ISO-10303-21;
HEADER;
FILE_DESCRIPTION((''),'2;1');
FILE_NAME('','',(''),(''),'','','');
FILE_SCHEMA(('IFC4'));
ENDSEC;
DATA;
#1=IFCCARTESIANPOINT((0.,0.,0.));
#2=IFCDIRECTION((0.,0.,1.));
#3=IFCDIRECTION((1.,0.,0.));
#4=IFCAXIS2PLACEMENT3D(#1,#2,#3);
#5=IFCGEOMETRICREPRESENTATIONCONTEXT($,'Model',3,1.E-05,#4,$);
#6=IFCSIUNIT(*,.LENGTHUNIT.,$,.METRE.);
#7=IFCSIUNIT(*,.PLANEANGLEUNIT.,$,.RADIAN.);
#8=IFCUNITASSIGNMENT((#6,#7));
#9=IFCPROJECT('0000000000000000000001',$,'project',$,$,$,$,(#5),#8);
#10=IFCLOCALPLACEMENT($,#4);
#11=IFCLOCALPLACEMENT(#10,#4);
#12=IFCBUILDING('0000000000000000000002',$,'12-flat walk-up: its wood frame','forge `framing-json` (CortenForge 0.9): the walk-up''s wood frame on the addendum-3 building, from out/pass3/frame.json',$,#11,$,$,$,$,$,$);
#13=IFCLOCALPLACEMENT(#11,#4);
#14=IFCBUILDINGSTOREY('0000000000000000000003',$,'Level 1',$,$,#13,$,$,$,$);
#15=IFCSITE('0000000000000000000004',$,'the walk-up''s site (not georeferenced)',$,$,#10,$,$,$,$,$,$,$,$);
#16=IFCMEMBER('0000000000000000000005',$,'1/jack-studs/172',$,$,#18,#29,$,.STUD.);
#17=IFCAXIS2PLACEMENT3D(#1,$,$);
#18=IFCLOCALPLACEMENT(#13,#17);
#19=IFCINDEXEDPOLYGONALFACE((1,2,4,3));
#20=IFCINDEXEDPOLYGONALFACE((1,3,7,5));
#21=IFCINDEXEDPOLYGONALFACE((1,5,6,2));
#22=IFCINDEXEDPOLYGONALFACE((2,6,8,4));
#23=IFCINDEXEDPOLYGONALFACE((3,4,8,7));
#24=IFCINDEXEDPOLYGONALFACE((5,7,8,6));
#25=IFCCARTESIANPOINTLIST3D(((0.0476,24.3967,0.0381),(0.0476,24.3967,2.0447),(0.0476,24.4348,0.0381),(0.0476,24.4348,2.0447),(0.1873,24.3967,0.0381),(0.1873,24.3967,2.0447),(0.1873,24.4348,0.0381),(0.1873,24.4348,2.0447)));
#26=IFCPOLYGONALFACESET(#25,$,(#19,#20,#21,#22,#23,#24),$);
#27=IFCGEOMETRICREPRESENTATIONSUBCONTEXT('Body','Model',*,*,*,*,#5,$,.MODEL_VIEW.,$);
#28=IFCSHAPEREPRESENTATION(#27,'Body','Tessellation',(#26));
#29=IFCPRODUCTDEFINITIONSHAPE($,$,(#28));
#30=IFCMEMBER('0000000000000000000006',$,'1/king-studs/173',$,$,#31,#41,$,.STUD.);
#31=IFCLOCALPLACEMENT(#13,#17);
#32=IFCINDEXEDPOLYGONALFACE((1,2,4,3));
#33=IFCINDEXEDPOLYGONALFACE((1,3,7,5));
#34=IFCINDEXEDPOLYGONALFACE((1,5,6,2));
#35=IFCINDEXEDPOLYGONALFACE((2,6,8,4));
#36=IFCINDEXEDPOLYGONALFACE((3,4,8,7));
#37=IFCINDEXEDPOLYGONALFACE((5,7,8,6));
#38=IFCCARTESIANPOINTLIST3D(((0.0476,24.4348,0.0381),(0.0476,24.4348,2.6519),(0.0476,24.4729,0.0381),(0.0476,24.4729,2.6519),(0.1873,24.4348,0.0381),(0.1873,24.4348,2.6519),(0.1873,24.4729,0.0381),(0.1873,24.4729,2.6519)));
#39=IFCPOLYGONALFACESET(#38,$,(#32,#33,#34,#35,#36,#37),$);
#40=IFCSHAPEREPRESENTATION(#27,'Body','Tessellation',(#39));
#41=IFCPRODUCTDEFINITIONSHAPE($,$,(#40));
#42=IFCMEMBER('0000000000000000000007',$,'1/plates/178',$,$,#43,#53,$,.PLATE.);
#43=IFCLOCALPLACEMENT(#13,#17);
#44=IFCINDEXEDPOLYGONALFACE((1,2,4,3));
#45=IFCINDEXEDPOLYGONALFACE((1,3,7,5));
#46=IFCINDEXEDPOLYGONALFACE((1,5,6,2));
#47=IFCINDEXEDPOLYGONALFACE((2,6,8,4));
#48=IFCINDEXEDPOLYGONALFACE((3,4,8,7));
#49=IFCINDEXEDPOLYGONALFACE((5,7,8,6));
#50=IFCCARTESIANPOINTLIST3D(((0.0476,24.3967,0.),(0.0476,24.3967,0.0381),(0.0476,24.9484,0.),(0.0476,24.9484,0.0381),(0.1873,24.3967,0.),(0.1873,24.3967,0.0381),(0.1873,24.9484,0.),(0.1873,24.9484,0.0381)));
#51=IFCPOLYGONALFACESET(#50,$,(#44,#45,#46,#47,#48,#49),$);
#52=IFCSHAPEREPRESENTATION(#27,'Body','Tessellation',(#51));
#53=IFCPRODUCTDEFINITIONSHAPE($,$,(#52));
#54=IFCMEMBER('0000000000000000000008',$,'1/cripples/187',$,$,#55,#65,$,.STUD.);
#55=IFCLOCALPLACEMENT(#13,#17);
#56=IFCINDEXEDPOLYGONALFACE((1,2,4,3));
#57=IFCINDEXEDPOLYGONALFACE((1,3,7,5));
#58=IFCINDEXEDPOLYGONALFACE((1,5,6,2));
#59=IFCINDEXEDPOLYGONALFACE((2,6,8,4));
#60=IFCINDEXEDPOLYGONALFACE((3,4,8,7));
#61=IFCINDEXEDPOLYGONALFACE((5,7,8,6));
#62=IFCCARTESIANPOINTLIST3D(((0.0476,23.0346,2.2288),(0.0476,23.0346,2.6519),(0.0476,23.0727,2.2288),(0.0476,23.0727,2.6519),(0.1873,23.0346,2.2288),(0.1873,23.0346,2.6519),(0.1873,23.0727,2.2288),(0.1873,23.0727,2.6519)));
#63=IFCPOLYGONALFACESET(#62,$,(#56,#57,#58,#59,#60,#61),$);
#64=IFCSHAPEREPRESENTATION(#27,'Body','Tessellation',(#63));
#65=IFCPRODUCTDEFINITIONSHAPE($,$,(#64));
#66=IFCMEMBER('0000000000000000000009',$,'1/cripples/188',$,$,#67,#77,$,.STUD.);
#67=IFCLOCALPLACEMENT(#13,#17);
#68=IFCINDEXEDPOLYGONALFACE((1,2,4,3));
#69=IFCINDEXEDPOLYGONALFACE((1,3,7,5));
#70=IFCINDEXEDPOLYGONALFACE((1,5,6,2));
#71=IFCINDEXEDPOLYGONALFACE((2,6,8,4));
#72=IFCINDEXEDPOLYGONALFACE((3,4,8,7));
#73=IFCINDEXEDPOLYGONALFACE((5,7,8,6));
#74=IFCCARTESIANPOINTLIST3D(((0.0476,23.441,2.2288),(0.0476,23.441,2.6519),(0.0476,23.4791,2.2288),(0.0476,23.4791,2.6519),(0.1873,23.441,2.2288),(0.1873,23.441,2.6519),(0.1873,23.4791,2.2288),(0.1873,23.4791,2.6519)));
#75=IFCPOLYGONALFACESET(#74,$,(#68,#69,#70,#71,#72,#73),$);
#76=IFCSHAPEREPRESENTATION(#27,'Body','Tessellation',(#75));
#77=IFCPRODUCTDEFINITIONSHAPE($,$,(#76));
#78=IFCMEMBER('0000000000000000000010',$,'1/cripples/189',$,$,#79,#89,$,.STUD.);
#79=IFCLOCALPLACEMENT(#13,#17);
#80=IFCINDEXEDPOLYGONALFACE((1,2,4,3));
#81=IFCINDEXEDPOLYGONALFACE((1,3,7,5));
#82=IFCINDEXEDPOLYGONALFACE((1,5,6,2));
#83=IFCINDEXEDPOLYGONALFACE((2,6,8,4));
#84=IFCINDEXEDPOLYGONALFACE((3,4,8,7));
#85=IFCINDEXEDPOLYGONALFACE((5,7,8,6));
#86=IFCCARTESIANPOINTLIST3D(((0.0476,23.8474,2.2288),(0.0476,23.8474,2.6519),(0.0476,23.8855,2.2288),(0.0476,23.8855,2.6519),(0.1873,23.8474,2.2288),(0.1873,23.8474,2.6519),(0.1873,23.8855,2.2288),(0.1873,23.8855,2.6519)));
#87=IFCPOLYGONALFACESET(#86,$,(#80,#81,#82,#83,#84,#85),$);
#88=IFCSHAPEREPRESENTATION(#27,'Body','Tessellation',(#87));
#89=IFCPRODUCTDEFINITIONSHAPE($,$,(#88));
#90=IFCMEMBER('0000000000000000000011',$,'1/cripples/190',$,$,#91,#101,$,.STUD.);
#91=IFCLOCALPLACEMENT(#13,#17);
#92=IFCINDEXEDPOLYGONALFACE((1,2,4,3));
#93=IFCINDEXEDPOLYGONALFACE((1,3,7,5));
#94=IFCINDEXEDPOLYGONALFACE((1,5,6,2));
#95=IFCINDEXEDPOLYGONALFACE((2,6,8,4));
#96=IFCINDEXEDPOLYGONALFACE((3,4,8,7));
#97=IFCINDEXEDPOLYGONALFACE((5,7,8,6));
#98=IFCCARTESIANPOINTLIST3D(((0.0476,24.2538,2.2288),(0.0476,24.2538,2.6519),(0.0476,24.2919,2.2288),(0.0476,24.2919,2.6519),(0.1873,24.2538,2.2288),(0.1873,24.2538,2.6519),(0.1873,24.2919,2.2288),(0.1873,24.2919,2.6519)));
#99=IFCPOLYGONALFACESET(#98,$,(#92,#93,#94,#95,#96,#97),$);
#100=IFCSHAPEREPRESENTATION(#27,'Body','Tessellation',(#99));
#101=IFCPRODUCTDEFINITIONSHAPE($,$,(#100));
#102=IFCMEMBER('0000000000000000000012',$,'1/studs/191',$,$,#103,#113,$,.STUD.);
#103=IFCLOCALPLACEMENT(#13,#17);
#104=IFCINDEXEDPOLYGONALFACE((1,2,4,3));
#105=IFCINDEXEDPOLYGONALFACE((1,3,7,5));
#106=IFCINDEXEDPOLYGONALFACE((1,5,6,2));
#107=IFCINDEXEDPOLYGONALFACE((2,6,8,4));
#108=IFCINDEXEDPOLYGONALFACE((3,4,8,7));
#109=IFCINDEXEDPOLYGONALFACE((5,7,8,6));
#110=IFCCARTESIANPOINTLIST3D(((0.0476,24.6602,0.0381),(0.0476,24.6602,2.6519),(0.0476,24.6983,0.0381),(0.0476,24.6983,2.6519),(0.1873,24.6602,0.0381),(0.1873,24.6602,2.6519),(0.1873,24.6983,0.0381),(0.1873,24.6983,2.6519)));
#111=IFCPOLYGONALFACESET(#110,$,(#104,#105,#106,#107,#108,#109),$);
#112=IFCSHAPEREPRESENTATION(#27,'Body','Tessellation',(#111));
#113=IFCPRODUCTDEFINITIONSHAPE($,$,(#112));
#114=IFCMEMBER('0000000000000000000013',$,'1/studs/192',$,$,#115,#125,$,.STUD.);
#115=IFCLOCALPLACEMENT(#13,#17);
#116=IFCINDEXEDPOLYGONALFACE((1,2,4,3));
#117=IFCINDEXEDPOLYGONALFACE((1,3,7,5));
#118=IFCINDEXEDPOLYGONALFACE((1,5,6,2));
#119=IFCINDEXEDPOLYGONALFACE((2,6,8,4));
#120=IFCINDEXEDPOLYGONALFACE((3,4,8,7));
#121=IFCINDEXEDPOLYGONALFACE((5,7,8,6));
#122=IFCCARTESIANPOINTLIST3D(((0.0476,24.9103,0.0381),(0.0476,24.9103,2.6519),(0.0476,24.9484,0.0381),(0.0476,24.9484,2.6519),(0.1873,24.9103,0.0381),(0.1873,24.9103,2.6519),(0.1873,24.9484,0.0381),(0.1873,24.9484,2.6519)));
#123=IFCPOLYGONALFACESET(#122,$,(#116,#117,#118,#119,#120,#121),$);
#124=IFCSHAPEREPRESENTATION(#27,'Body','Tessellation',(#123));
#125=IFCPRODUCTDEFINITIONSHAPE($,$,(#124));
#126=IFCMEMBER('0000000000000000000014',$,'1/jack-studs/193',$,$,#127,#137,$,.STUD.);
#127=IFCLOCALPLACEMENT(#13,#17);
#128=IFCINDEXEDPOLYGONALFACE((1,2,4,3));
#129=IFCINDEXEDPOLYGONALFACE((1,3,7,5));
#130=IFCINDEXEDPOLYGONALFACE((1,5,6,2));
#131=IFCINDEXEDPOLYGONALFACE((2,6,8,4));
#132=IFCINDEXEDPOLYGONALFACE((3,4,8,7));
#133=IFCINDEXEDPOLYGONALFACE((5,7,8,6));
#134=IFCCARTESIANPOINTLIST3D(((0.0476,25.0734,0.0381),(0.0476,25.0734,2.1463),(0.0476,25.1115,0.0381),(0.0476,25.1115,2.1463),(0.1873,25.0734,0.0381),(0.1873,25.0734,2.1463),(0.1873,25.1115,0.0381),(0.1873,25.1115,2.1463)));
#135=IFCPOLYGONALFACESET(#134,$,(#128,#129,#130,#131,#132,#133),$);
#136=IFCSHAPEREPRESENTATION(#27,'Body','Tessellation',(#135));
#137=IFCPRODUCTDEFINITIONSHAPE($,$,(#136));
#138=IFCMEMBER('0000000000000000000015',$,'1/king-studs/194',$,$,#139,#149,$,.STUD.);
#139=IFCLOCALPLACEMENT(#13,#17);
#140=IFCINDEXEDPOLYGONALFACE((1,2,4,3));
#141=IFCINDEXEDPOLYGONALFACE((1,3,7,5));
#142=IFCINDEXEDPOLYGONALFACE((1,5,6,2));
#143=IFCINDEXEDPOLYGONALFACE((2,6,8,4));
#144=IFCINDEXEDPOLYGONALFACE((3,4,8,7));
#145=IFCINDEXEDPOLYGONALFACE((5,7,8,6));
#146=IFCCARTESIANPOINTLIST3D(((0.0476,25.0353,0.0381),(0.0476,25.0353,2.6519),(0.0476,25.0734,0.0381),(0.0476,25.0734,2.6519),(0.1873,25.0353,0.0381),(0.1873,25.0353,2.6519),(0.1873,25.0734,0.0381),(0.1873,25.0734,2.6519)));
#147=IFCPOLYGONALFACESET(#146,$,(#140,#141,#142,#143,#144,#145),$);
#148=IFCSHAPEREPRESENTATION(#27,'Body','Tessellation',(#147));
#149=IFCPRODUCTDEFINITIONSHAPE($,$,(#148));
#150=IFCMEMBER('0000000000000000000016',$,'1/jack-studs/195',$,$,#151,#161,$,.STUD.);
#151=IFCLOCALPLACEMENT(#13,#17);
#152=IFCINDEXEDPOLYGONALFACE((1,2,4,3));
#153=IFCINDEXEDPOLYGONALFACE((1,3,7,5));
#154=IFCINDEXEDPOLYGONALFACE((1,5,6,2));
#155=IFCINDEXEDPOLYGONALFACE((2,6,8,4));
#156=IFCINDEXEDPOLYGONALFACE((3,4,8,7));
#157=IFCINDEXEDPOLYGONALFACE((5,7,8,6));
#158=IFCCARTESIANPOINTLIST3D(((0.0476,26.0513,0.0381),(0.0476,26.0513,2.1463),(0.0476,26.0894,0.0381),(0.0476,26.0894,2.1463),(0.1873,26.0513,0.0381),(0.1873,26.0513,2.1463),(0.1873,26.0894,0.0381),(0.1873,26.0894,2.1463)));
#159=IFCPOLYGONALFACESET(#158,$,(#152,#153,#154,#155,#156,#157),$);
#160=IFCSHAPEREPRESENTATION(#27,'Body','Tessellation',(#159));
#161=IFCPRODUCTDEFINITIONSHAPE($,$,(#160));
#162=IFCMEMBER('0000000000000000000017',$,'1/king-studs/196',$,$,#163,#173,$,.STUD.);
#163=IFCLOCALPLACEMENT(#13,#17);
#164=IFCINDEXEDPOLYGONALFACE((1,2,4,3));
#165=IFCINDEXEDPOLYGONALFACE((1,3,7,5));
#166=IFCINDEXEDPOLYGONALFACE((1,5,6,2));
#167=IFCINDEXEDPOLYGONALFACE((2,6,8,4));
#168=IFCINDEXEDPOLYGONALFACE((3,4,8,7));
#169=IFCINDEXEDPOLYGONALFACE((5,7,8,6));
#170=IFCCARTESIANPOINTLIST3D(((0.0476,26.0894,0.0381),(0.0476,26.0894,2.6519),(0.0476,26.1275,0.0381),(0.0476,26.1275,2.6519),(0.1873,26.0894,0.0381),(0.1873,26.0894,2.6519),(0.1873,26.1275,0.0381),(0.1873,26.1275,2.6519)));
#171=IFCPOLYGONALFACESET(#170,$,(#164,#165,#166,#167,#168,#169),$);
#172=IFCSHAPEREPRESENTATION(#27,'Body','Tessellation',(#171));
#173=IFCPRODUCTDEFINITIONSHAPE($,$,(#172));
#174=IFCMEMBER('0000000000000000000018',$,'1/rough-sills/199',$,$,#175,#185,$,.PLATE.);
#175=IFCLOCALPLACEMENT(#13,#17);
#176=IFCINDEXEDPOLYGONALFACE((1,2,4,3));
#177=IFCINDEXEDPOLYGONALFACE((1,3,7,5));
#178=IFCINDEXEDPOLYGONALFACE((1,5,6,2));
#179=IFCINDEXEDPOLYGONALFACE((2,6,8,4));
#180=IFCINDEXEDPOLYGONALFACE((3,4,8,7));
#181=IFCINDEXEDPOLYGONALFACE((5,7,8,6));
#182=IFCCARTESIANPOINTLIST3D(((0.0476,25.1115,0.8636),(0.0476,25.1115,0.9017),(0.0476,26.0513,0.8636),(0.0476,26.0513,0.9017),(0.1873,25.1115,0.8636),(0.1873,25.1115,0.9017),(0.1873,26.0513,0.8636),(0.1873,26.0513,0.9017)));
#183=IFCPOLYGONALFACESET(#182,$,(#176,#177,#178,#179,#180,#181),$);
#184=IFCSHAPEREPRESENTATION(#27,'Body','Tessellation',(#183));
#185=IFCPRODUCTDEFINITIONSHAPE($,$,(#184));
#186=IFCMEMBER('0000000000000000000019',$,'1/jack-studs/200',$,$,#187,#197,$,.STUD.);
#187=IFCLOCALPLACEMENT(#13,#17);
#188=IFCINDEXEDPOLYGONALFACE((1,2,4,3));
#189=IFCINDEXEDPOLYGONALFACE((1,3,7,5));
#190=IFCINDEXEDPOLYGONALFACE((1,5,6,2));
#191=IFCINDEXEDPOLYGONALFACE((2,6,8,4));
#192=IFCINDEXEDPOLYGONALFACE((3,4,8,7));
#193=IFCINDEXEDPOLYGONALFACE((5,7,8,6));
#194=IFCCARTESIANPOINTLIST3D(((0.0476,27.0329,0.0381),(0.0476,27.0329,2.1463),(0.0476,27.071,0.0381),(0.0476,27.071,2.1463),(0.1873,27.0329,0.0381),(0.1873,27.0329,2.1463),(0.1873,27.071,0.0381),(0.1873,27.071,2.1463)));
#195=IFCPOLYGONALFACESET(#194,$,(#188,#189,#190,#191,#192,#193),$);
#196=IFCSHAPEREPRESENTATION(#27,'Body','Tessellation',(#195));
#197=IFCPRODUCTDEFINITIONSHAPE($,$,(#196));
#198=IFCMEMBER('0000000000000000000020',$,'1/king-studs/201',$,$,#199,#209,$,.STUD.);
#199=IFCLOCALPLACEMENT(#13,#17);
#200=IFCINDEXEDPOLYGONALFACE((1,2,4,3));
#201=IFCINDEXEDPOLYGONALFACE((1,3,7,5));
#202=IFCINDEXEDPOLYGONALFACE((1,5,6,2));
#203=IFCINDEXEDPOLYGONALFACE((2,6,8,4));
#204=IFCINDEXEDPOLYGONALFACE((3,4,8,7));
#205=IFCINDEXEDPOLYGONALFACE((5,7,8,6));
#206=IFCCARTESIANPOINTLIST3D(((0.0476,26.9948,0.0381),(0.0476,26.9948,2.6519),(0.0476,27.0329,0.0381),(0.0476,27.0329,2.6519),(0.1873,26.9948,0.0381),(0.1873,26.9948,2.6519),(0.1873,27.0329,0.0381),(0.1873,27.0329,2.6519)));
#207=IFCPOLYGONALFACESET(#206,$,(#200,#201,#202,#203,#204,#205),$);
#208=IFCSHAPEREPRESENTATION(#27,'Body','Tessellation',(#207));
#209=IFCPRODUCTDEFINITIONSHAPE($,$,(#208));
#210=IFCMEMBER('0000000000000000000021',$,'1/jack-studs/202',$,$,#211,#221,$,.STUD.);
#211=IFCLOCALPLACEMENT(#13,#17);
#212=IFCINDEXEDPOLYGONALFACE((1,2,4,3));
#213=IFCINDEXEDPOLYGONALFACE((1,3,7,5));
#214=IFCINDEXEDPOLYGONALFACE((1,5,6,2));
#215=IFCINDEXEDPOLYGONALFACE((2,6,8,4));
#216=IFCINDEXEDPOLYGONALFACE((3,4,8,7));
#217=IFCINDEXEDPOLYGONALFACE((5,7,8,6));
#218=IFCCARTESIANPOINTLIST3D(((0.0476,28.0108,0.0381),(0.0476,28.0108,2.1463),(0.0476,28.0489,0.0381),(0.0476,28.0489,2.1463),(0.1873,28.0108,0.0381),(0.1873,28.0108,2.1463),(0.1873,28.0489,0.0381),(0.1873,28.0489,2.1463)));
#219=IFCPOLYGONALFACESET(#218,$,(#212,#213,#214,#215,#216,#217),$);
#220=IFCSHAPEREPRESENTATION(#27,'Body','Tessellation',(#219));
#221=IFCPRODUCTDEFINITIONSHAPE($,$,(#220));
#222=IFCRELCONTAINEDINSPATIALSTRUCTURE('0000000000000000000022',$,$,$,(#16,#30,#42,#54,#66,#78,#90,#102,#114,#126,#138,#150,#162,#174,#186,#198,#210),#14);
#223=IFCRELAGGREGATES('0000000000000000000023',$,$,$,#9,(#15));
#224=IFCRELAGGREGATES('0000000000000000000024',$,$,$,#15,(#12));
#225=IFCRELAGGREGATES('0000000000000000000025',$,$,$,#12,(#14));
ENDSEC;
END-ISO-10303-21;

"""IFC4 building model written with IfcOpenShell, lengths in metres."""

from ifc_helpers import new_model, si_unit, frame, frame_2d, origin, origin_with_axes, place, context, subcontext, project, spatial, rectangle, extrude, element, save


model = new_model("IFC4")

# Units and contexts
model_context = context("Model", 3, precision=1e-05, world=origin_with_axes())
body_context = subcontext(model_context, "Body", "Model", "MODEL_VIEW")
ifc_project = project(units=[si_unit("LENGTHUNIT", "METRE"), si_unit("PLANEANGLEUNIT", "RADIAN")], contexts=[model_context])

# Site, building, storey
site_placement = place(None, origin_with_axes())
site = spatial("IfcSite", under=ifc_project, at=site_placement, Name="the walk-up's site (not georeferenced)")
building_placement = place(site_placement, origin_with_axes())
building = spatial("IfcBuilding", under=site, at=building_placement, Name="12-flat walk-up: its wood frame", Description="forge `framing-json` (CortenForge 0.9): the walk-up's wood frame on the addendum-3 building, from out/pass3/frame.json")
storey_placement = place(building_placement, origin_with_axes())
storey = spatial("IfcBuildingStorey", under=building, at=storey_placement, Name="Level 1")

# Members
member_1_placement = place(storey_placement, frame((0.0476, 24.3967, 0.0381), z_axis=(0.0, 0.0, 1.0), x_axis=(1.0, 0.0, 0.0)))
element("IfcMember", 1, at=member_1_placement, inside=storey, Name="1/jack-studs/172", PredefinedType="STUD", context=body_context, shape_type="SweptSolid", body=[
    extrude(rectangle(XDim=0.1397, YDim=0.0381, at=frame_2d((0.0698, 0.0191))), origin(), (0.0, 0.0, 1.0), 2.0066),
])
member_2_placement = place(storey_placement, frame((0.0476, 24.4348, 0.0381), z_axis=(0.0, 0.0, 1.0), x_axis=(1.0, 0.0, 0.0)))
element("IfcMember", 2, at=member_2_placement, inside=storey, Name="1/king-studs/173", PredefinedType="STUD", context=body_context, shape_type="SweptSolid", body=[
    extrude(rectangle(XDim=0.1397, YDim=0.0381, at=frame_2d((0.0698, 0.0191))), origin(), (0.0, 0.0, 1.0), 2.6138),
])
member_3_placement = place(storey_placement, frame((0.0476, 24.3967, 0.0), z_axis=(0.0, 0.0, 1.0), x_axis=(1.0, 0.0, 0.0)))
element("IfcMember", 3, at=member_3_placement, inside=storey, Name="1/plates/178", PredefinedType="PLATE", context=body_context, shape_type="SweptSolid", body=[
    extrude(rectangle(XDim=0.1397, YDim=0.5517, at=frame_2d((0.0698, 0.2759))), origin(), (0.0, 0.0, 1.0), 0.0381),
])
for number, where, z_axis, x_axis, name in (
    (4, (0.0476, 23.0346, 2.2288), (0.0, 0.0, 1.0), (1.0, 0.0, 0.0), "1/cripples/187"),
    (5, (0.0476, 23.441, 2.2288), (0.0, 0.0, 1.0), (1.0, 0.0, 0.0), "1/cripples/188"),
    (6, (0.0476, 23.8474, 2.2288), (0.0, 0.0, 1.0), (1.0, 0.0, 0.0), "1/cripples/189"),
    (7, (0.0476, 24.2538, 2.2288), (0.0, 0.0, 1.0), (1.0, 0.0, 0.0), "1/cripples/190"),
):
    element("IfcMember", number, at=place(storey_placement, frame(where, z_axis=z_axis, x_axis=x_axis)), inside=storey, Name=name, PredefinedType="STUD", context=body_context, shape_type="SweptSolid", body=[
        extrude(rectangle(XDim=0.1397, YDim=0.0381, at=frame_2d((0.0698, 0.0191))), origin(), (0.0, 0.0, 1.0), 0.4231),
    ])
for number, where, z_axis, x_axis, name in (
    (8, (0.0476, 24.6602, 0.0381), (0.0, 0.0, 1.0), (1.0, 0.0, 0.0), "1/studs/191"),
    (9, (0.0476, 24.9103, 0.0381), (0.0, 0.0, 1.0), (1.0, 0.0, 0.0), "1/studs/192"),
):
    element("IfcMember", number, at=place(storey_placement, frame(where, z_axis=z_axis, x_axis=x_axis)), inside=storey, Name=name, PredefinedType="STUD", context=body_context, shape_type="SweptSolid", body=[
        extrude(rectangle(XDim=0.1397, YDim=0.0381, at=frame_2d((0.0698, 0.0191))), origin(), (0.0, 0.0, 1.0), 2.6138),
    ])
member_4_placement = place(storey_placement, frame((0.0476, 25.0734, 0.0381), z_axis=(0.0, 0.0, 1.0), x_axis=(1.0, 0.0, 0.0)))
element("IfcMember", 10, at=member_4_placement, inside=storey, Name="1/jack-studs/193", PredefinedType="STUD", context=body_context, shape_type="SweptSolid", body=[
    extrude(rectangle(XDim=0.1397, YDim=0.0381, at=frame_2d((0.0698, 0.0191))), origin(), (0.0, 0.0, 1.0), 2.1082),
])
member_5_placement = place(storey_placement, frame((0.0476, 25.0353, 0.0381), z_axis=(0.0, 0.0, 1.0), x_axis=(1.0, 0.0, 0.0)))
element("IfcMember", 11, at=member_5_placement, inside=storey, Name="1/king-studs/194", PredefinedType="STUD", context=body_context, shape_type="SweptSolid", body=[
    extrude(rectangle(XDim=0.1397, YDim=0.0381, at=frame_2d((0.0698, 0.0191))), origin(), (0.0, 0.0, 1.0), 2.6138),
])
member_6_placement = place(storey_placement, frame((0.0476, 26.0513, 0.0381), z_axis=(0.0, 0.0, 1.0), x_axis=(1.0, 0.0, 0.0)))
element("IfcMember", 12, at=member_6_placement, inside=storey, Name="1/jack-studs/195", PredefinedType="STUD", context=body_context, shape_type="SweptSolid", body=[
    extrude(rectangle(XDim=0.1397, YDim=0.0381, at=frame_2d((0.0698, 0.0191))), origin(), (0.0, 0.0, 1.0), 2.1082),
])
member_7_placement = place(storey_placement, frame((0.0476, 26.0894, 0.0381), z_axis=(0.0, 0.0, 1.0), x_axis=(1.0, 0.0, 0.0)))
element("IfcMember", 13, at=member_7_placement, inside=storey, Name="1/king-studs/196", PredefinedType="STUD", context=body_context, shape_type="SweptSolid", body=[
    extrude(rectangle(XDim=0.1397, YDim=0.0381, at=frame_2d((0.0698, 0.0191))), origin(), (0.0, 0.0, 1.0), 2.6138),
])
member_8_placement = place(storey_placement, frame((0.0476, 25.1115, 0.8636), z_axis=(0.0, 0.0, 1.0), x_axis=(1.0, 0.0, 0.0)))
element("IfcMember", 14, at=member_8_placement, inside=storey, Name="1/rough-sills/199", PredefinedType="PLATE", context=body_context, shape_type="SweptSolid", body=[
    extrude(rectangle(XDim=0.1397, YDim=0.9398, at=frame_2d((0.0698, 0.4699))), origin(), (0.0, 0.0, 1.0), 0.0381),
])
member_9_placement = place(storey_placement, frame((0.0476, 27.0329, 0.0381), z_axis=(0.0, 0.0, 1.0), x_axis=(1.0, 0.0, 0.0)))
element("IfcMember", 15, at=member_9_placement, inside=storey, Name="1/jack-studs/200", PredefinedType="STUD", context=body_context, shape_type="SweptSolid", body=[
    extrude(rectangle(XDim=0.1397, YDim=0.0381, at=frame_2d((0.0698, 0.0191))), origin(), (0.0, 0.0, 1.0), 2.1082),
])
member_10_placement = place(storey_placement, frame((0.0476, 26.9948, 0.0381), z_axis=(0.0, 0.0, 1.0), x_axis=(1.0, 0.0, 0.0)))
element("IfcMember", 16, at=member_10_placement, inside=storey, Name="1/king-studs/201", PredefinedType="STUD", context=body_context, shape_type="SweptSolid", body=[
    extrude(rectangle(XDim=0.1397, YDim=0.0381, at=frame_2d((0.0698, 0.0191))), origin(), (0.0, 0.0, 1.0), 2.6138),
])
member_11_placement = place(storey_placement, frame((0.0476, 28.0108, 0.0381), z_axis=(0.0, 0.0, 1.0), x_axis=(1.0, 0.0, 0.0)))
element("IfcMember", 17, at=member_11_placement, inside=storey, Name="1/jack-studs/202", PredefinedType="STUD", context=body_context, shape_type="SweptSolid", body=[
    extrude(rectangle(XDim=0.1397, YDim=0.0381, at=frame_2d((0.0698, 0.0191))), origin(), (0.0, 0.0, 1.0), 2.1082),
])

save(model, "model.ifc")
